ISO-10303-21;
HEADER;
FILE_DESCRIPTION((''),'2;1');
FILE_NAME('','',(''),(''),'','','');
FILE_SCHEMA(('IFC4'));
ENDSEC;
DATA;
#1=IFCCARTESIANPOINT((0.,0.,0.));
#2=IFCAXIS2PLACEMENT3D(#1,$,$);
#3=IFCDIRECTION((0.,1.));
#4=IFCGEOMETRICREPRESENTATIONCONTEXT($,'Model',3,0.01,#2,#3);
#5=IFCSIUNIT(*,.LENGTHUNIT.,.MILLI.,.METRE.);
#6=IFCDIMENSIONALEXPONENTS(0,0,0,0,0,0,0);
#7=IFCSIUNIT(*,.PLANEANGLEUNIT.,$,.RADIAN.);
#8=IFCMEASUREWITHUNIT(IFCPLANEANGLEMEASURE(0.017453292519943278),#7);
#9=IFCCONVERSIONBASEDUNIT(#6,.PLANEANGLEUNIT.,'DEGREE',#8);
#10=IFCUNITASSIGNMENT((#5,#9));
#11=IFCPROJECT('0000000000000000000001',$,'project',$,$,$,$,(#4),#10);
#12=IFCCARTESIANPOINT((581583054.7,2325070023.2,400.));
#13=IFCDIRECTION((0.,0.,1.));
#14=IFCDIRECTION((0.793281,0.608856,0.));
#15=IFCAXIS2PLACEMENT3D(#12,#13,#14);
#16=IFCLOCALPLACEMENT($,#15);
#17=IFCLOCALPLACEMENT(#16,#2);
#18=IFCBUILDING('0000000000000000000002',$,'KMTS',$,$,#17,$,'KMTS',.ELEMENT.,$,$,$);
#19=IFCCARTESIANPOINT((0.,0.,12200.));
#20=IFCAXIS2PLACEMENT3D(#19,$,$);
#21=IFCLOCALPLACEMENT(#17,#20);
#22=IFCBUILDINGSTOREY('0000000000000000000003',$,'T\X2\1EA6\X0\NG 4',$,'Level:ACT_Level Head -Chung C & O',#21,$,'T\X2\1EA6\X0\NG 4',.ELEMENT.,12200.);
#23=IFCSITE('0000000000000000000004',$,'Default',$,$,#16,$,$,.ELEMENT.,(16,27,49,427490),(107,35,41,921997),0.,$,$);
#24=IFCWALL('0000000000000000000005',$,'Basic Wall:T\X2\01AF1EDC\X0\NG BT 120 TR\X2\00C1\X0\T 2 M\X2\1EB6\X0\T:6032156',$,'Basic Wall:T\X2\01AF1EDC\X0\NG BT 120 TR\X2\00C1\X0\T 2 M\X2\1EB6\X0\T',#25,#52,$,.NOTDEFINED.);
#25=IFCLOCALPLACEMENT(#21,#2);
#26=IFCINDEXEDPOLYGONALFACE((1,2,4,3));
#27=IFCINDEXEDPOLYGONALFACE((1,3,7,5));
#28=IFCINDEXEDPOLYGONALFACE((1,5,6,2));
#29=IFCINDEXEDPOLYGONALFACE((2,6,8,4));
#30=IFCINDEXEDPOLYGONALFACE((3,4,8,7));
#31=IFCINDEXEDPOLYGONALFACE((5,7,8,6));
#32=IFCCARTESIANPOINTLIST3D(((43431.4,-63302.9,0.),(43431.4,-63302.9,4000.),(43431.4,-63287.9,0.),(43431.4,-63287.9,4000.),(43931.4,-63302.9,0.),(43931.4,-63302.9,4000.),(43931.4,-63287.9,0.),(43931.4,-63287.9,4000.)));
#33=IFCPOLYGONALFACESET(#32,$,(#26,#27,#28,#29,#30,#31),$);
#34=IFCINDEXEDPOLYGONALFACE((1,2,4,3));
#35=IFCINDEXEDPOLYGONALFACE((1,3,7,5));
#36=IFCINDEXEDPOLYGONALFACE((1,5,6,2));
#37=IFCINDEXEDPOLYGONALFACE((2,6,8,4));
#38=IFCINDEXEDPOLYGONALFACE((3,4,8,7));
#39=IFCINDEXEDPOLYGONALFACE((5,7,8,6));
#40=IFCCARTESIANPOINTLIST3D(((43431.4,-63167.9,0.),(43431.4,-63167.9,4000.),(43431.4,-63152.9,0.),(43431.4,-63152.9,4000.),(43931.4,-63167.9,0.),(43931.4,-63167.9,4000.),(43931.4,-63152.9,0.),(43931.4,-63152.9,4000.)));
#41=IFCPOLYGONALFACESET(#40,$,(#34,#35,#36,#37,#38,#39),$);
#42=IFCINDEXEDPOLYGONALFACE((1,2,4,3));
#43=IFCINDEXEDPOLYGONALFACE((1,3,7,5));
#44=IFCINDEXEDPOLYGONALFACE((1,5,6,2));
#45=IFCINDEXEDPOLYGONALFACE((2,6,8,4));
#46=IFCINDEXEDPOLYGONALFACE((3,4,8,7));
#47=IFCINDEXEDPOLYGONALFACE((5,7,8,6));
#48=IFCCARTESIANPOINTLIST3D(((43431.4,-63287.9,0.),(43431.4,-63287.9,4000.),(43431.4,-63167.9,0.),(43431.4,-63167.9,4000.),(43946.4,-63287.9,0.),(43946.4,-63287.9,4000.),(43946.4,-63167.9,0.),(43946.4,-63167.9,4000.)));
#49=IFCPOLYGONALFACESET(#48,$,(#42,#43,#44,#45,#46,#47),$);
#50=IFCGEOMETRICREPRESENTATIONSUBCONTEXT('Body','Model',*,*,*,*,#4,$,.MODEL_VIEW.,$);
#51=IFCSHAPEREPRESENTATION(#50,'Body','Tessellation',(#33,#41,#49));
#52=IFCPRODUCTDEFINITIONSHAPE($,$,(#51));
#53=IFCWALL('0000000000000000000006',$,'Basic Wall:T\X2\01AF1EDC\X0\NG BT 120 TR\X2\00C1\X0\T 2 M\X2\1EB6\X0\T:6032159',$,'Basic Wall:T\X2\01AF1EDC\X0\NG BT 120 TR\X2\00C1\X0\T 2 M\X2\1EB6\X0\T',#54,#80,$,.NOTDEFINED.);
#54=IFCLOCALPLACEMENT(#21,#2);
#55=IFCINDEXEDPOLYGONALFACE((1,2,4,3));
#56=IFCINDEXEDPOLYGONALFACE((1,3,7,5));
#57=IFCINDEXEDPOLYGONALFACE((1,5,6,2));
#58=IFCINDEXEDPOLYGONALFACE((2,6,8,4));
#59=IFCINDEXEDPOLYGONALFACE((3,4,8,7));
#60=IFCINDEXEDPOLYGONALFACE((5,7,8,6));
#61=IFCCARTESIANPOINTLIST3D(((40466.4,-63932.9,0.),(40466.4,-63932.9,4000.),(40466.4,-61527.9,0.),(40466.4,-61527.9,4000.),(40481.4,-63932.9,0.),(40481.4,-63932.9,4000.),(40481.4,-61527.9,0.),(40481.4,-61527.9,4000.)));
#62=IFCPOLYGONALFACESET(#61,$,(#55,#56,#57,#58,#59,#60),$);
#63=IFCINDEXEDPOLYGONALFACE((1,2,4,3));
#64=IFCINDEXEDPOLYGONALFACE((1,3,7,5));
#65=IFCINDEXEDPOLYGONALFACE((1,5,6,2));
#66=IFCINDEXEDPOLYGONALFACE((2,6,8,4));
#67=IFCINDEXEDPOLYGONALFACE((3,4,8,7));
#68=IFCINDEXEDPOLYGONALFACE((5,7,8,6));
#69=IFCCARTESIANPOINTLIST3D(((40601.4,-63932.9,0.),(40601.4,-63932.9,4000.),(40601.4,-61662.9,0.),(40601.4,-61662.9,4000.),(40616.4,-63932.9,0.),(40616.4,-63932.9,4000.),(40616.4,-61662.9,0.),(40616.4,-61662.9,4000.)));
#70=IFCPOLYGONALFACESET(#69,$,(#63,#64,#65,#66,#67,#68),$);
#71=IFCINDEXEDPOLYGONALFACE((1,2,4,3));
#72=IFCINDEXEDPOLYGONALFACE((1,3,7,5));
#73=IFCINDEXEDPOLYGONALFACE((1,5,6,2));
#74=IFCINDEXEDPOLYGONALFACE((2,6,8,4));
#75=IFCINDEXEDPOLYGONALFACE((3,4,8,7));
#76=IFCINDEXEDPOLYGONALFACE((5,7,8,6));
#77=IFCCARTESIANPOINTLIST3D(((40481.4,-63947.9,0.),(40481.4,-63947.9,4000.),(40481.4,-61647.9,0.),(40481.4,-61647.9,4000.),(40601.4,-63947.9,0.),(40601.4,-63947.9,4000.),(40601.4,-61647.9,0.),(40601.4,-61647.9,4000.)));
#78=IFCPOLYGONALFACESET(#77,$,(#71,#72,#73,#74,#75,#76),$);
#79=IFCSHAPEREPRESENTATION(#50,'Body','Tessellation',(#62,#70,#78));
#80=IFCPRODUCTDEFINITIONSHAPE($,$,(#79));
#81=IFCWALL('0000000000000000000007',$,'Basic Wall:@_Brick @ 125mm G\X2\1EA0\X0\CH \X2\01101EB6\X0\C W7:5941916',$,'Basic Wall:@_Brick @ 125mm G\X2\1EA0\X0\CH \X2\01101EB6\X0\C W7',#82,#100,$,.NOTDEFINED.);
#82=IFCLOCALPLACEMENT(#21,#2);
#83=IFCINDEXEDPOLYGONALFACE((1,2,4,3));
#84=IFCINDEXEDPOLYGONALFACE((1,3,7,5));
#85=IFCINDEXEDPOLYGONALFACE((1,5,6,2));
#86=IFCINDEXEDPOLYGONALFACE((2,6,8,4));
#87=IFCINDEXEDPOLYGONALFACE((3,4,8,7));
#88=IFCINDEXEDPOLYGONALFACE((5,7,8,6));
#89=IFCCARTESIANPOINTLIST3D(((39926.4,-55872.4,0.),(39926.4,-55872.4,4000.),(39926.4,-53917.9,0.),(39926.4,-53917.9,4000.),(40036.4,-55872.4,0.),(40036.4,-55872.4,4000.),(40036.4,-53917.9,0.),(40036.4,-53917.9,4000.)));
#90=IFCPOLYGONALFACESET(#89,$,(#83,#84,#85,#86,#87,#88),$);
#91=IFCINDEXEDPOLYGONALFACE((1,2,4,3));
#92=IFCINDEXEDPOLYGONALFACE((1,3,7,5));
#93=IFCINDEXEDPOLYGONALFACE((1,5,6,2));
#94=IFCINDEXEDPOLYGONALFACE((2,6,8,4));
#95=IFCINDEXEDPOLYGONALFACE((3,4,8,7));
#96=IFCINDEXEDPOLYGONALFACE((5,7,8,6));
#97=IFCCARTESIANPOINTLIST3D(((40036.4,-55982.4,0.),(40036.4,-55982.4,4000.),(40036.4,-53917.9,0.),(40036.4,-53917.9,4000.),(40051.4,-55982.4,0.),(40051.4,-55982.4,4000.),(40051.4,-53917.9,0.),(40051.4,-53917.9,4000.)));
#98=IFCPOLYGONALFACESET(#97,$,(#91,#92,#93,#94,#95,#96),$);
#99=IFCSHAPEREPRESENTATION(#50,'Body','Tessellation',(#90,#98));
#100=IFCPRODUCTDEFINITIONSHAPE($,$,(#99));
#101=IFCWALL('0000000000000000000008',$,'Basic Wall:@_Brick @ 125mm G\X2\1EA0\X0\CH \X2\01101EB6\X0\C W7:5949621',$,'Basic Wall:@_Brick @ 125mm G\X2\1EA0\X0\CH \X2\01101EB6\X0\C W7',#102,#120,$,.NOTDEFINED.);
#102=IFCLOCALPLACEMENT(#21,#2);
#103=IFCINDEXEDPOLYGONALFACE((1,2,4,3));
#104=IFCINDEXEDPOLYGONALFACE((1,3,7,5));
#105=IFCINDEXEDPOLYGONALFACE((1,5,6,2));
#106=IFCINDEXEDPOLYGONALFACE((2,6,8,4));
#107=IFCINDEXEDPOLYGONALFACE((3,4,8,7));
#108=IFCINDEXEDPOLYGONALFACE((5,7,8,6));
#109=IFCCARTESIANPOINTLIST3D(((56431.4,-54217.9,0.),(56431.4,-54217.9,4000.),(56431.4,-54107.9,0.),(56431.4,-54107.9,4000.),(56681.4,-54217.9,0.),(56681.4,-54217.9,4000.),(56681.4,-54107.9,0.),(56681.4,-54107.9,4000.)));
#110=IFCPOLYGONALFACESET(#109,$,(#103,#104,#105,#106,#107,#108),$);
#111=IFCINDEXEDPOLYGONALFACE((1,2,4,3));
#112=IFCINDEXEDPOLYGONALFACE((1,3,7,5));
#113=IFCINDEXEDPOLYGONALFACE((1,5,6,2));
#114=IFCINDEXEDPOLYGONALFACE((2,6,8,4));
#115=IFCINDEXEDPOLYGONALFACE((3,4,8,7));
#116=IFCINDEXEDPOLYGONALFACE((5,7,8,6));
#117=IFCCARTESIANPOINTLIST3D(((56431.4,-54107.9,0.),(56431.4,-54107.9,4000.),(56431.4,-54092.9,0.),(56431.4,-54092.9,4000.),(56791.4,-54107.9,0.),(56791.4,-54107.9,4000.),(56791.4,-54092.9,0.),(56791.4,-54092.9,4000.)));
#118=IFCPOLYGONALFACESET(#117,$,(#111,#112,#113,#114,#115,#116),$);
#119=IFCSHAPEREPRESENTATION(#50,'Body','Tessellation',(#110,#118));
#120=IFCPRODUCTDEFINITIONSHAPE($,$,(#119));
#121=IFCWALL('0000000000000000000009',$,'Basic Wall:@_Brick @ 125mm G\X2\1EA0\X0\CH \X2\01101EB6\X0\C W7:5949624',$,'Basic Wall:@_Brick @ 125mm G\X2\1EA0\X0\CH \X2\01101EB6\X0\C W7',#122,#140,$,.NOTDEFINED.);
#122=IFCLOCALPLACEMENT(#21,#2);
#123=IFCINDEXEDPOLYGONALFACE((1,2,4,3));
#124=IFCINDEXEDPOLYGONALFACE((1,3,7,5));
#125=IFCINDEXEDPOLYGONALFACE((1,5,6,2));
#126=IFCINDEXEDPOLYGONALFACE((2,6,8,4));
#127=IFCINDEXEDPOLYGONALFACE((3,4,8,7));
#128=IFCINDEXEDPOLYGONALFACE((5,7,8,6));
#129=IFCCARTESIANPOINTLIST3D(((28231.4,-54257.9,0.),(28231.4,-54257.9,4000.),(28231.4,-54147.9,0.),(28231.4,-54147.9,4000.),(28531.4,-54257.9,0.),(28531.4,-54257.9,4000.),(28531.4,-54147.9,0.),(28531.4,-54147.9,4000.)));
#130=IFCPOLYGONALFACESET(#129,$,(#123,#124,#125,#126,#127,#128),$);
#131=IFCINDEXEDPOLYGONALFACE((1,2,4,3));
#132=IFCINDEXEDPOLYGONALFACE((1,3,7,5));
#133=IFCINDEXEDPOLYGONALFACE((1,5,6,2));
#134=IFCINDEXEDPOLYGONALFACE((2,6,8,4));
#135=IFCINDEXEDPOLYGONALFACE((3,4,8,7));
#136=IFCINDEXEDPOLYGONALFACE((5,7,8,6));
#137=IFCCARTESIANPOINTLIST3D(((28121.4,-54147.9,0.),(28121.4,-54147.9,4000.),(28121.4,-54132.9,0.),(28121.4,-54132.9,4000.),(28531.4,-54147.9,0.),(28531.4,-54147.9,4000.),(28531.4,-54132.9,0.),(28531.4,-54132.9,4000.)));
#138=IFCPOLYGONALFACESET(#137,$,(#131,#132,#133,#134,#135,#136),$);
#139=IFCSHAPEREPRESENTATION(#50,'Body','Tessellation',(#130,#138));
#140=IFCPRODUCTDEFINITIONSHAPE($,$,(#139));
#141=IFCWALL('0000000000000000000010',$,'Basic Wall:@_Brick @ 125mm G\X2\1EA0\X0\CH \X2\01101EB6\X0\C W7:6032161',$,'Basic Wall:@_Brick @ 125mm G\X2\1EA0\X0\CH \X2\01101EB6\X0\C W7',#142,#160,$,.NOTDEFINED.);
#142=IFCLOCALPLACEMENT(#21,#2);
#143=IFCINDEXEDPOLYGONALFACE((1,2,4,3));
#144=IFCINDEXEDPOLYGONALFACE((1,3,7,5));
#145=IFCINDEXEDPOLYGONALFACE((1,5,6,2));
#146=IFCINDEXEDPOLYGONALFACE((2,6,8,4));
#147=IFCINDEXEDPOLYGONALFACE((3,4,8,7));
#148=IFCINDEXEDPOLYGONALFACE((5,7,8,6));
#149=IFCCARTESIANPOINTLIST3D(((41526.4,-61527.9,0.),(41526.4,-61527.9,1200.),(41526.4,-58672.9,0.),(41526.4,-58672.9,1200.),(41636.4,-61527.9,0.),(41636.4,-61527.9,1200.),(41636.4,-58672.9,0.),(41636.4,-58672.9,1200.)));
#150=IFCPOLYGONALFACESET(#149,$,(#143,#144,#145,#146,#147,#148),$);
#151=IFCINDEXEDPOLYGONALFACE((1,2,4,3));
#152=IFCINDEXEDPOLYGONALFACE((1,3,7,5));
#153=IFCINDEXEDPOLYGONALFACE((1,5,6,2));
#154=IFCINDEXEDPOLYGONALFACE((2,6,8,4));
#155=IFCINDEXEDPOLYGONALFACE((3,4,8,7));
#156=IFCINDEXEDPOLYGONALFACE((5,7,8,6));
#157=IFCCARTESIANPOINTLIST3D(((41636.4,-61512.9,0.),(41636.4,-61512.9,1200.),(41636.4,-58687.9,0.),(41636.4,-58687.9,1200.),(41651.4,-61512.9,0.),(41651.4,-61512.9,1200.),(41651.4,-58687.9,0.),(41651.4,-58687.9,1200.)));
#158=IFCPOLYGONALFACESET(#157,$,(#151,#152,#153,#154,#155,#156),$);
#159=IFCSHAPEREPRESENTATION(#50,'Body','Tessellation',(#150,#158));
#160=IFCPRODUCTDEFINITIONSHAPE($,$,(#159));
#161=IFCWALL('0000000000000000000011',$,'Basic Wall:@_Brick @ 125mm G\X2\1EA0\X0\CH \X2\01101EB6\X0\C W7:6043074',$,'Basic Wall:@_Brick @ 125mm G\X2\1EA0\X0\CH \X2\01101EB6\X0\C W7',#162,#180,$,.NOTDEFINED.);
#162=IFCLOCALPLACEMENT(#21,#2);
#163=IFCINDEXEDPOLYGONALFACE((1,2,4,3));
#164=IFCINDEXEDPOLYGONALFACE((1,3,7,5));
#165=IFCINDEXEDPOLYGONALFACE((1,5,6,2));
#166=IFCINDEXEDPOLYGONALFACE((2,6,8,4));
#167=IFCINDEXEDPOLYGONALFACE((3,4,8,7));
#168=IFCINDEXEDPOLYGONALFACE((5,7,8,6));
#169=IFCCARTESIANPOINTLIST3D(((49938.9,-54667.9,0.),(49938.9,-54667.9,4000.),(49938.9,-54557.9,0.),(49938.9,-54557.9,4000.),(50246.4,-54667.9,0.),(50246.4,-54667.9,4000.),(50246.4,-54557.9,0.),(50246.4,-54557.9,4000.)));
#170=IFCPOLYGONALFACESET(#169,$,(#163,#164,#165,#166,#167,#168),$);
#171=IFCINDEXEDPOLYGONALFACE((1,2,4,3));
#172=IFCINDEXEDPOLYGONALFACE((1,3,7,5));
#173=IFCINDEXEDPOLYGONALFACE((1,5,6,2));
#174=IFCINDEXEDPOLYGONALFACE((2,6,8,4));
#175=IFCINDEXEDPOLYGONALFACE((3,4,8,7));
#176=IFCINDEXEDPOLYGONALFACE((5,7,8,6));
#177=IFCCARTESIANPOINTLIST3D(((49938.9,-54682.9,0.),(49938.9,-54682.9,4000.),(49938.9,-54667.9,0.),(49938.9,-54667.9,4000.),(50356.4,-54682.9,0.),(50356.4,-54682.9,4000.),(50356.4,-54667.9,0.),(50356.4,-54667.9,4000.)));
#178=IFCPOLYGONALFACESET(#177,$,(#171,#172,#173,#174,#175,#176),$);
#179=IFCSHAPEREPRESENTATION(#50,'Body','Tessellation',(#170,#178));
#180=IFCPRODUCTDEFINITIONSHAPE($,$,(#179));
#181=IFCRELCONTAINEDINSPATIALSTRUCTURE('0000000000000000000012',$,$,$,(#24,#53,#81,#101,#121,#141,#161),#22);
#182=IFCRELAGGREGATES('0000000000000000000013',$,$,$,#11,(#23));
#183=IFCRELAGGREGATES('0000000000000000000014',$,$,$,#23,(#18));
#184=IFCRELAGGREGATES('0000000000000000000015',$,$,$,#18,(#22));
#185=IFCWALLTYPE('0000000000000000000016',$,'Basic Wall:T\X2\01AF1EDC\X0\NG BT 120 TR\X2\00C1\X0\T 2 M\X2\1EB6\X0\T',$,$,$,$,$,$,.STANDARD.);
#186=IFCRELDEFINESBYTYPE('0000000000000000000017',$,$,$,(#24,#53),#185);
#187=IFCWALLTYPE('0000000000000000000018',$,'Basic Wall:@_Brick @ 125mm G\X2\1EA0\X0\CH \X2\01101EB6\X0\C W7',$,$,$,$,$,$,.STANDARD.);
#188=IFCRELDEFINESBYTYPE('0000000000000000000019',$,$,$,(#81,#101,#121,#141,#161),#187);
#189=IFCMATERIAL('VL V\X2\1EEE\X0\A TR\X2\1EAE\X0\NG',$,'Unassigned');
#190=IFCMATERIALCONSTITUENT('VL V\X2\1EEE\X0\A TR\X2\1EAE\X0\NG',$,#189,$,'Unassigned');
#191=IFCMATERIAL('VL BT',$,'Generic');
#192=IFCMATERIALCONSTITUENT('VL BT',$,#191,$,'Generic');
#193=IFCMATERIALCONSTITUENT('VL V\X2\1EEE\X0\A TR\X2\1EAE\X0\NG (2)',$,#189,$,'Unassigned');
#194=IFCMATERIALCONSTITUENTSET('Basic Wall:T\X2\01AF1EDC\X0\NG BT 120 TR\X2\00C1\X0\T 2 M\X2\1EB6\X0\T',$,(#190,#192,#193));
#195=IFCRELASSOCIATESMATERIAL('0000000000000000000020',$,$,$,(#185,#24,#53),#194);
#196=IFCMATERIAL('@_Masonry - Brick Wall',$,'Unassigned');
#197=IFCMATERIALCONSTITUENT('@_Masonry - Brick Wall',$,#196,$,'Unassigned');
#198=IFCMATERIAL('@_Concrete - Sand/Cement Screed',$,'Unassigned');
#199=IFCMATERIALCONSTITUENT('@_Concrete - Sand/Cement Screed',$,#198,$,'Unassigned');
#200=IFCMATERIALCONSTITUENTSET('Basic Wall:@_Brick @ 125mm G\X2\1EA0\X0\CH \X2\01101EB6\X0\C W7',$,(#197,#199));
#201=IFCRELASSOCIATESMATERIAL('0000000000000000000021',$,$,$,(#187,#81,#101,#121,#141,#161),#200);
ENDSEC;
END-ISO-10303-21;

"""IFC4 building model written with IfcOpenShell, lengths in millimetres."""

from ifc_helpers import new_model, entity, si_unit, converted_unit, direction, frame, origin, place, context, subcontext, project, spatial, indexed_curve, outline, extrude, material, constituent, constituent_set, type_object, element, save


model = new_model("IFC4")

# Units and contexts
model_context = context("Model", 3, precision=0.01, world=origin(), true_north=direction((0.0, 1.0)))
body_context = subcontext(model_context, "Body", "Model", "MODEL_VIEW")
ifc_project = project(units=[si_unit("LENGTHUNIT", "METRE", prefix="MILLI"), converted_unit("PLANEANGLEUNIT", "DEGREE", entity("IfcPlaneAngleMeasure", 0.017453292519943278), si_unit("PLANEANGLEUNIT", "RADIAN"), dimensions=[0, 0, 0, 0, 0, 0, 0])], contexts=[model_context])

# Site, building, storey
site_placement = place(None, frame((581583054.7, 2325070023.2, 400.0), z_axis=(0.0, 0.0, 1.0), x_axis=(0.793281, 0.608856, 0.0)))
site = spatial("IfcSite", under=ifc_project, at=site_placement, Name="Default", CompositionType="ELEMENT", RefLatitude=(16, 27, 49, 427490), RefLongitude=(107, 35, 41, 921997), RefElevation=0.0)
building_placement = place(site_placement, origin())
building = spatial("IfcBuilding", under=site, at=building_placement, Name="KMTS", LongName="KMTS", CompositionType="ELEMENT")
storey_placement = place(building_placement, frame((0.0, 0.0, 12200.0)))
storey = spatial("IfcBuildingStorey", under=building, at=storey_placement, Name="TẦNG 4", ObjectType="Level:ACT_Level Head -Chung C & O", LongName="TẦNG 4", CompositionType="ELEMENT", Elevation=12200.0)

# Shared definitions
ifc_material_1 = material(Name="VL VỮA TRẮNG", Category="Unassigned")
ifc_material_2 = material(Name="VL BT", Category="Generic")

# Shared definitions
ifc_constituent_1 = constituent(ifc_material_1, Name="VL VỮA TRẮNG", Category="Unassigned")
ifc_constituent_2 = constituent(ifc_material_2, Name="VL BT", Category="Generic")
ifc_constituent_3 = constituent(ifc_material_1, Name="VL VỮA TRẮNG (2)", Category="Unassigned")
ifc_constituent_set_1 = constituent_set(constituents=[ifc_constituent_1, ifc_constituent_2, ifc_constituent_3], Name="Basic Wall:TƯỜNG BT 120 TRÁT 2 MẶT")
wall_type_1 = type_object("IfcWallType", Name="Basic Wall:TƯỜNG BT 120 TRÁT 2 MẶT", PredefinedType="STANDARD", material=ifc_constituent_set_1)

# Walls
wall_1_placement = place(storey_placement, frame((43431.4, -63227.9, 0.0)))
element("IfcWall", 1, at=wall_1_placement, inside=storey, type_object=wall_type_1, material=ifc_constituent_set_1, Name="Basic Wall:TƯỜNG BT 120 TRÁT 2 MẶT:6032156", ObjectType="Basic Wall:TƯỜNG BT 120 TRÁT 2 MẶT", PredefinedType="NOTDEFINED", context=body_context, shape_type="SweptSolid", body=[
    extrude(outline(indexed_curve([(-7.5, -250.0), (7.5, -250.0), (7.5, 250.0), (-7.5, 250.0), (-7.5, -250.0)], self_intersect=False)), frame((250.0, -67.5, 0.0), z_axis=(0.0, 0.0, 1.0), x_axis=(0.0, 1.0, 0.0)), (0.0, 0.0, 1.0), 4000.0),
    extrude(outline(indexed_curve([(-7.5, -250.0), (7.5, -250.0), (7.5, 250.0), (-7.5, 250.0), (-7.5, -250.0)], self_intersect=False)), frame((250.0, 67.5, 0.0), z_axis=(0.0, 0.0, 1.0), x_axis=(0.0, -1.0, 0.0)), (0.0, 0.0, 1.0), 4000.0),
    extrude(outline(indexed_curve([(-257.5, -60.0), (257.5, -60.0), (257.5, 60.0), (-257.5, 60.0), (-257.5, -60.0)], self_intersect=False)), frame((257.5, 0.0, 0.0)), (0.0, 0.0, 1.0), 4000.0),
])
wall_2_placement = place(storey_placement, frame((40541.4, -61662.9, 0.0), z_axis=(0.0, 0.0, 1.0), x_axis=(0.0, -1.0, 0.0)))
element("IfcWall", 2, at=wall_2_placement, inside=storey, type_object=wall_type_1, material=ifc_constituent_set_1, Name="Basic Wall:TƯỜNG BT 120 TRÁT 2 MẶT:6032159", ObjectType="Basic Wall:TƯỜNG BT 120 TRÁT 2 MẶT", PredefinedType="NOTDEFINED", context=body_context, shape_type="SweptSolid", body=[
    extrude(outline(indexed_curve([(-7.5, -1202.5), (7.5, -1202.5), (7.5, 1202.5), (-7.5, 1202.5), (-7.5, -1202.5)], self_intersect=False)), frame((1067.5, -67.5, 0.0), z_axis=(0.0, 0.0, 1.0), x_axis=(0.0, 1.0, 0.0)), (0.0, 0.0, 1.0), 4000.0),
    extrude(outline(indexed_curve([(-7.5, -1135.0), (7.5, -1135.0), (7.5, 1135.0), (-7.5, 1135.0), (-7.5, -1135.0)], self_intersect=False)), frame((1135.0, 67.5, 0.0), z_axis=(0.0, 0.0, 1.0), x_axis=(0.0, -1.0, 0.0)), (0.0, 0.0, 1.0), 4000.0),
    extrude(outline(indexed_curve([(-1150.0, -60.0), (1150.0, -60.0), (1150.0, 60.0), (-1150.0, 60.0), (-1150.0, -60.0)], self_intersect=False)), frame((1135.0, 0.0, 0.0)), (0.0, 0.0, 1.0), 4000.0),
])
ifc_material_3 = material(Name="@_Masonry - Brick Wall", Category="Unassigned")
ifc_constituent_4 = constituent(ifc_material_3, Name="@_Masonry - Brick Wall", Category="Unassigned")
ifc_material_4 = material(Name="@_Concrete - Sand/Cement Screed", Category="Unassigned")
ifc_constituent_5 = constituent(ifc_material_4, Name="@_Concrete - Sand/Cement Screed", Category="Unassigned")
ifc_constituent_set_2 = constituent_set(constituents=[ifc_constituent_4, ifc_constituent_5], Name="Basic Wall:@_Brick @ 125mm GẠCH ĐẶC W7")
wall_type_2 = type_object("IfcWallType", Name="Basic Wall:@_Brick @ 125mm GẠCH ĐẶC W7", PredefinedType="STANDARD", material=ifc_constituent_set_2)
wall_3_placement = place(storey_placement, frame((39988.9, -55872.4, 0.0), z_axis=(0.0, 0.0, 1.0), x_axis=(0.0, 1.0, 0.0)))
element("IfcWall", 3, at=wall_3_placement, inside=storey, type_object=wall_type_2, material=ifc_constituent_set_2, Name="Basic Wall:@_Brick @ 125mm GẠCH ĐẶC W7:5941916", ObjectType="Basic Wall:@_Brick @ 125mm GẠCH ĐẶC W7", PredefinedType="NOTDEFINED", context=body_context, shape_type="SweptSolid", body=[
    extrude(outline(indexed_curve([(-55.0, -977.2), (55.0, -977.2), (55.0, 977.2), (-55.0, 977.2), (-55.0, -977.2)], self_intersect=False)), frame((977.2, 7.5, 0.0), z_axis=(0.0, 0.0, 1.0), x_axis=(0.0, -1.0, 0.0)), (0.0, 0.0, 1.0), 4000.0),
    extrude(outline(indexed_curve([(-7.5, -1032.2), (7.5, -1032.2), (7.5, 1032.2), (-7.5, 1032.2), (-7.5, -1032.2)], self_intersect=False)), frame((922.2, -55.0, 0.0), z_axis=(0.0, 0.0, 1.0), x_axis=(0.0, 1.0, 0.0)), (0.0, 0.0, 1.0), 4000.0),
])
wall_4_placement = place(storey_placement, frame((56681.4, -54155.4, 0.0), z_axis=(0.0, 0.0, 1.0), x_axis=(-1.0, 0.0, 0.0)))
element("IfcWall", 4, at=wall_4_placement, inside=storey, type_object=wall_type_2, material=ifc_constituent_set_2, Name="Basic Wall:@_Brick @ 125mm GẠCH ĐẶC W7:5949621", ObjectType="Basic Wall:@_Brick @ 125mm GẠCH ĐẶC W7", PredefinedType="NOTDEFINED", context=body_context, shape_type="SweptSolid", body=[
    extrude(outline(indexed_curve([(-55.0, -125.0), (55.0, -125.0), (55.0, 125.0), (-55.0, 125.0), (-55.0, -125.0)], self_intersect=False)), frame((125.0, 7.5, 0.0), z_axis=(0.0, 0.0, 1.0), x_axis=(0.0, -1.0, 0.0)), (0.0, 0.0, 1.0), 4000.0),
    extrude(outline(indexed_curve([(-7.5, -180.0), (7.5, -180.0), (7.5, 180.0), (-7.5, 180.0), (-7.5, -180.0)], self_intersect=False)), frame((70.0, -55.0, 0.0), z_axis=(0.0, 0.0, 1.0), x_axis=(0.0, 1.0, 0.0)), (0.0, 0.0, 1.0), 4000.0),
])
wall_5_placement = place(storey_placement, frame((28531.4, -54195.4, 0.0), z_axis=(0.0, 0.0, 1.0), x_axis=(-1.0, 0.0, 0.0)))
element("IfcWall", 5, at=wall_5_placement, inside=storey, type_object=wall_type_2, material=ifc_constituent_set_2, Name="Basic Wall:@_Brick @ 125mm GẠCH ĐẶC W7:5949624", ObjectType="Basic Wall:@_Brick @ 125mm GẠCH ĐẶC W7", PredefinedType="NOTDEFINED", context=body_context, shape_type="SweptSolid", body=[
    extrude(outline(indexed_curve([(-55.0, -150.0), (55.0, -150.0), (55.0, 150.0), (-55.0, 150.0), (-55.0, -150.0)], self_intersect=False)), frame((150.0, 7.5, 0.0), z_axis=(0.0, 0.0, 1.0), x_axis=(0.0, -1.0, 0.0)), (0.0, 0.0, 1.0), 4000.0),
    extrude(outline(indexed_curve([(-7.5, -205.0), (7.5, -205.0), (7.5, 205.0), (-7.5, 205.0), (-7.5, -205.0)], self_intersect=False)), frame((205.0, -55.0, 0.0), z_axis=(0.0, 0.0, 1.0), x_axis=(0.0, 1.0, 0.0)), (0.0, 0.0, 1.0), 4000.0),
])
wall_6_placement = place(storey_placement, frame((41588.9, -61512.9, 0.0), z_axis=(0.0, 0.0, 1.0), x_axis=(0.0, 1.0, 0.0)))
element("IfcWall", 6, at=wall_6_placement, inside=storey, type_object=wall_type_2, material=ifc_constituent_set_2, Name="Basic Wall:@_Brick @ 125mm GẠCH ĐẶC W7:6032161", ObjectType="Basic Wall:@_Brick @ 125mm GẠCH ĐẶC W7", PredefinedType="NOTDEFINED", context=body_context, shape_type="SweptSolid", body=[
    extrude(outline(indexed_curve([(-55.0, -1427.5), (55.0, -1427.5), (55.0, 1427.5), (-55.0, 1427.5), (-55.0, -1427.5)], self_intersect=False)), frame((1412.5, 7.5, 0.0), z_axis=(0.0, 0.0, 1.0), x_axis=(0.0, -1.0, 0.0)), (0.0, 0.0, 1.0), 1200.0),
    extrude(outline(indexed_curve([(-7.5, -1412.5), (7.5, -1412.5), (7.5, 1412.5), (-7.5, 1412.5), (-7.5, -1412.5)], self_intersect=False)), frame((1412.5, -55.0, 0.0), z_axis=(0.0, 0.0, 1.0), x_axis=(0.0, 1.0, 0.0)), (0.0, 0.0, 1.0), 1200.0),
])
wall_7_placement = place(storey_placement, frame((50246.4, -54620.4, 0.0), z_axis=(0.0, 0.0, 1.0), x_axis=(-1.0, 0.0, 0.0)))
element("IfcWall", 7, at=wall_7_placement, inside=storey, type_object=wall_type_2, material=ifc_constituent_set_2, Name="Basic Wall:@_Brick @ 125mm GẠCH ĐẶC W7:6043074", ObjectType="Basic Wall:@_Brick @ 125mm GẠCH ĐẶC W7", PredefinedType="NOTDEFINED", context=body_context, shape_type="SweptSolid", body=[
    extrude(outline(indexed_curve([(-55.0, -153.8), (55.0, -153.8), (55.0, 153.8), (-55.0, 153.8), (-55.0, -153.8)], self_intersect=False)), frame((153.8, -7.5, 0.0), z_axis=(0.0, 0.0, 1.0), x_axis=(0.0, 1.0, 0.0)), (0.0, 0.0, 1.0), 4000.0),
    extrude(outline(indexed_curve([(-7.5, -208.8), (7.5, -208.8), (7.5, 208.8), (-7.5, 208.8), (-7.5, -208.8)], self_intersect=False)), frame((98.8, 55.0, 0.0), z_axis=(0.0, 0.0, 1.0), x_axis=(0.0, -1.0, 0.0)), (0.0, 0.0, 1.0), 4000.0),
])

save(model, "model.ifc")
